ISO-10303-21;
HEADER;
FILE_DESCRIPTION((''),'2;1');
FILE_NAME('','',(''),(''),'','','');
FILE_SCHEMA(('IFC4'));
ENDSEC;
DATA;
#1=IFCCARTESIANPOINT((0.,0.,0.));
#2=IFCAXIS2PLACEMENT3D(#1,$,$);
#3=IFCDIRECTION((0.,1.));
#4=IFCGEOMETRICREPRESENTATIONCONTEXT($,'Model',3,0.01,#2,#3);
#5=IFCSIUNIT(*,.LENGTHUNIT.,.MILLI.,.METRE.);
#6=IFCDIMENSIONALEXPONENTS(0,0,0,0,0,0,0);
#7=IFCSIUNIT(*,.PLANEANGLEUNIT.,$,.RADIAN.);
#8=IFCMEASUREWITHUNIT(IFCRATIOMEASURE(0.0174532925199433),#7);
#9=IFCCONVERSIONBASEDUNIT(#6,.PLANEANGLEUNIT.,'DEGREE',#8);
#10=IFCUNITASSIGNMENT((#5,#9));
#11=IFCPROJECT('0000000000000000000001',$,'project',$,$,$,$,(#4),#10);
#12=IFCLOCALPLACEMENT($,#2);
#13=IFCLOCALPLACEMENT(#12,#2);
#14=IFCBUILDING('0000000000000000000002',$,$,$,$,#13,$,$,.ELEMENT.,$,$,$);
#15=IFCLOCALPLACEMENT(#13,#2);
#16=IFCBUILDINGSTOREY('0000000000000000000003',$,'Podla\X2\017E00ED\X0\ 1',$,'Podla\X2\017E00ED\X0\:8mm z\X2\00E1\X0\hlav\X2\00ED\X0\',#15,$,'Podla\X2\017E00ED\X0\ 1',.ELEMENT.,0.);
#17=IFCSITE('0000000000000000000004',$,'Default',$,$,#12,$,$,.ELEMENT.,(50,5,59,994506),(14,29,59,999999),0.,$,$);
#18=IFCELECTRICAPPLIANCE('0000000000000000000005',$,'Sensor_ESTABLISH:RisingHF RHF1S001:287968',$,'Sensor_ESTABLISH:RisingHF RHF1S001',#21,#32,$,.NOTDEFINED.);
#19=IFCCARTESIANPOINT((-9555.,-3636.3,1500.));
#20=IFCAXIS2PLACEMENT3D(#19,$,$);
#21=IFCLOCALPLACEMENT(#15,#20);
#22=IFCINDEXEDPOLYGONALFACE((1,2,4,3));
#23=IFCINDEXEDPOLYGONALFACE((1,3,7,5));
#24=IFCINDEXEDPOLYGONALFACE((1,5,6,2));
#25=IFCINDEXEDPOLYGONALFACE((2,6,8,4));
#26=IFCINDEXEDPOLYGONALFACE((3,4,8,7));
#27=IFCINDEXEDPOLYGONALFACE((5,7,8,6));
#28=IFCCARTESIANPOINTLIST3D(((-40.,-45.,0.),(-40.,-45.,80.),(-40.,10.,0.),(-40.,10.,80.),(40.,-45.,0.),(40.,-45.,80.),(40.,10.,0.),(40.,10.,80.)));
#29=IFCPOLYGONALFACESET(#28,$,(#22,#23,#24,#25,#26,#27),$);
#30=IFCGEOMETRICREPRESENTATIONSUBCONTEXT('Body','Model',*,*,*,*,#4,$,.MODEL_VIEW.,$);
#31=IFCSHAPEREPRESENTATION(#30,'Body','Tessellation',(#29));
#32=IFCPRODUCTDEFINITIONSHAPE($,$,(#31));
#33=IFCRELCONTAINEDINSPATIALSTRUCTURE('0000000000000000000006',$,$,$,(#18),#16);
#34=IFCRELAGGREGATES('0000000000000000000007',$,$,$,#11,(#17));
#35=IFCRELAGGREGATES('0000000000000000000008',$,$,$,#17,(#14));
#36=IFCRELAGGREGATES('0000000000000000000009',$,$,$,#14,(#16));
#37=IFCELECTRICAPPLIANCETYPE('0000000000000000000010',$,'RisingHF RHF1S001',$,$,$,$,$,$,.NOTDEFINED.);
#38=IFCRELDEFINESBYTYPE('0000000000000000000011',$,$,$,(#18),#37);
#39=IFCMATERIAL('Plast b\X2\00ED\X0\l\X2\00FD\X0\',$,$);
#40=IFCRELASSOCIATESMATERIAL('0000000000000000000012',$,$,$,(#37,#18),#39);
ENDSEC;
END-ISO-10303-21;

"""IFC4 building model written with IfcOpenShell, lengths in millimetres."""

from ifc_helpers import new_model, entity, si_unit, converted_unit, direction, frame, frame_2d, origin, place, context, subcontext, project, spatial, rectangle, extrude, source, transform, mapped, material, type_object, type_shapes, element, save


model = new_model("IFC4")

# Units and contexts
model_context = context("Model", 3, precision=0.01, world=origin(), true_north=direction((0.0, 1.0)))
body_context = subcontext(model_context, "Body", "Model", "MODEL_VIEW")
ifc_project = project(units=[si_unit("LENGTHUNIT", "METRE", prefix="MILLI"), converted_unit("PLANEANGLEUNIT", "DEGREE", entity("IfcRatioMeasure", 0.0174532925199433), si_unit("PLANEANGLEUNIT", "RADIAN"), dimensions=[0, 0, 0, 0, 0, 0, 0])], contexts=[model_context])

# Site, building, storey
site_placement = place(None, origin())
site = spatial("IfcSite", under=ifc_project, at=site_placement, Name="Default", CompositionType="ELEMENT", RefLatitude=(50, 5, 59, 994506), RefLongitude=(14, 29, 59, 999999), RefElevation=0.0)
building_placement = place(site_placement, origin())
building = spatial("IfcBuilding", under=site, at=building_placement, CompositionType="ELEMENT")
storey_placement = place(building_placement, origin())
storey = spatial("IfcBuildingStorey", under=building, at=storey_placement, Name="Podlaží 1", ObjectType="Podlaží:8mm záhlaví", LongName="Podlaží 1", CompositionType="ELEMENT", Elevation=0.0)

# Electric appliance
ifc_material_1 = material(Name="Plast bílý")
electric_appliance_type_1 = type_object("IfcElectricApplianceType", Name="RisingHF RHF1S001", PredefinedType="NOTDEFINED", material=ifc_material_1)
shared_shape_1 = source(origin(), body_context, "Body", "SweptSolid", [
    extrude(rectangle(XDim=80.0, YDim=55.0, at=frame_2d((0.0, 0.0), x_axis=(1.0, 0.0))), frame((0.0, -17.5, 0.0), z_axis=(0.0, 0.0, 1.0), x_axis=(-1.0, 0.0, 0.0)), (0.0, 0.0, 1.0), 80.0),
])
type_shapes(electric_appliance_type_1, [shared_shape_1])
electric_appliance_1_placement = place(storey_placement, frame((-9555.0, -3636.3, 1500.0)))
element("IfcElectricAppliance", 1, at=electric_appliance_1_placement, inside=storey, type_object=electric_appliance_type_1, material=ifc_material_1, Name="Sensor_ESTABLISH:RisingHF RHF1S001:287968", ObjectType="Sensor_ESTABLISH:RisingHF RHF1S001", PredefinedType="NOTDEFINED", context=body_context, shape_type="MappedRepresentation", body=[
    mapped(shared_shape_1, transform((0.0, 0.0, 0.0), scale=1.0)),
])

save(model, "model.ifc")
